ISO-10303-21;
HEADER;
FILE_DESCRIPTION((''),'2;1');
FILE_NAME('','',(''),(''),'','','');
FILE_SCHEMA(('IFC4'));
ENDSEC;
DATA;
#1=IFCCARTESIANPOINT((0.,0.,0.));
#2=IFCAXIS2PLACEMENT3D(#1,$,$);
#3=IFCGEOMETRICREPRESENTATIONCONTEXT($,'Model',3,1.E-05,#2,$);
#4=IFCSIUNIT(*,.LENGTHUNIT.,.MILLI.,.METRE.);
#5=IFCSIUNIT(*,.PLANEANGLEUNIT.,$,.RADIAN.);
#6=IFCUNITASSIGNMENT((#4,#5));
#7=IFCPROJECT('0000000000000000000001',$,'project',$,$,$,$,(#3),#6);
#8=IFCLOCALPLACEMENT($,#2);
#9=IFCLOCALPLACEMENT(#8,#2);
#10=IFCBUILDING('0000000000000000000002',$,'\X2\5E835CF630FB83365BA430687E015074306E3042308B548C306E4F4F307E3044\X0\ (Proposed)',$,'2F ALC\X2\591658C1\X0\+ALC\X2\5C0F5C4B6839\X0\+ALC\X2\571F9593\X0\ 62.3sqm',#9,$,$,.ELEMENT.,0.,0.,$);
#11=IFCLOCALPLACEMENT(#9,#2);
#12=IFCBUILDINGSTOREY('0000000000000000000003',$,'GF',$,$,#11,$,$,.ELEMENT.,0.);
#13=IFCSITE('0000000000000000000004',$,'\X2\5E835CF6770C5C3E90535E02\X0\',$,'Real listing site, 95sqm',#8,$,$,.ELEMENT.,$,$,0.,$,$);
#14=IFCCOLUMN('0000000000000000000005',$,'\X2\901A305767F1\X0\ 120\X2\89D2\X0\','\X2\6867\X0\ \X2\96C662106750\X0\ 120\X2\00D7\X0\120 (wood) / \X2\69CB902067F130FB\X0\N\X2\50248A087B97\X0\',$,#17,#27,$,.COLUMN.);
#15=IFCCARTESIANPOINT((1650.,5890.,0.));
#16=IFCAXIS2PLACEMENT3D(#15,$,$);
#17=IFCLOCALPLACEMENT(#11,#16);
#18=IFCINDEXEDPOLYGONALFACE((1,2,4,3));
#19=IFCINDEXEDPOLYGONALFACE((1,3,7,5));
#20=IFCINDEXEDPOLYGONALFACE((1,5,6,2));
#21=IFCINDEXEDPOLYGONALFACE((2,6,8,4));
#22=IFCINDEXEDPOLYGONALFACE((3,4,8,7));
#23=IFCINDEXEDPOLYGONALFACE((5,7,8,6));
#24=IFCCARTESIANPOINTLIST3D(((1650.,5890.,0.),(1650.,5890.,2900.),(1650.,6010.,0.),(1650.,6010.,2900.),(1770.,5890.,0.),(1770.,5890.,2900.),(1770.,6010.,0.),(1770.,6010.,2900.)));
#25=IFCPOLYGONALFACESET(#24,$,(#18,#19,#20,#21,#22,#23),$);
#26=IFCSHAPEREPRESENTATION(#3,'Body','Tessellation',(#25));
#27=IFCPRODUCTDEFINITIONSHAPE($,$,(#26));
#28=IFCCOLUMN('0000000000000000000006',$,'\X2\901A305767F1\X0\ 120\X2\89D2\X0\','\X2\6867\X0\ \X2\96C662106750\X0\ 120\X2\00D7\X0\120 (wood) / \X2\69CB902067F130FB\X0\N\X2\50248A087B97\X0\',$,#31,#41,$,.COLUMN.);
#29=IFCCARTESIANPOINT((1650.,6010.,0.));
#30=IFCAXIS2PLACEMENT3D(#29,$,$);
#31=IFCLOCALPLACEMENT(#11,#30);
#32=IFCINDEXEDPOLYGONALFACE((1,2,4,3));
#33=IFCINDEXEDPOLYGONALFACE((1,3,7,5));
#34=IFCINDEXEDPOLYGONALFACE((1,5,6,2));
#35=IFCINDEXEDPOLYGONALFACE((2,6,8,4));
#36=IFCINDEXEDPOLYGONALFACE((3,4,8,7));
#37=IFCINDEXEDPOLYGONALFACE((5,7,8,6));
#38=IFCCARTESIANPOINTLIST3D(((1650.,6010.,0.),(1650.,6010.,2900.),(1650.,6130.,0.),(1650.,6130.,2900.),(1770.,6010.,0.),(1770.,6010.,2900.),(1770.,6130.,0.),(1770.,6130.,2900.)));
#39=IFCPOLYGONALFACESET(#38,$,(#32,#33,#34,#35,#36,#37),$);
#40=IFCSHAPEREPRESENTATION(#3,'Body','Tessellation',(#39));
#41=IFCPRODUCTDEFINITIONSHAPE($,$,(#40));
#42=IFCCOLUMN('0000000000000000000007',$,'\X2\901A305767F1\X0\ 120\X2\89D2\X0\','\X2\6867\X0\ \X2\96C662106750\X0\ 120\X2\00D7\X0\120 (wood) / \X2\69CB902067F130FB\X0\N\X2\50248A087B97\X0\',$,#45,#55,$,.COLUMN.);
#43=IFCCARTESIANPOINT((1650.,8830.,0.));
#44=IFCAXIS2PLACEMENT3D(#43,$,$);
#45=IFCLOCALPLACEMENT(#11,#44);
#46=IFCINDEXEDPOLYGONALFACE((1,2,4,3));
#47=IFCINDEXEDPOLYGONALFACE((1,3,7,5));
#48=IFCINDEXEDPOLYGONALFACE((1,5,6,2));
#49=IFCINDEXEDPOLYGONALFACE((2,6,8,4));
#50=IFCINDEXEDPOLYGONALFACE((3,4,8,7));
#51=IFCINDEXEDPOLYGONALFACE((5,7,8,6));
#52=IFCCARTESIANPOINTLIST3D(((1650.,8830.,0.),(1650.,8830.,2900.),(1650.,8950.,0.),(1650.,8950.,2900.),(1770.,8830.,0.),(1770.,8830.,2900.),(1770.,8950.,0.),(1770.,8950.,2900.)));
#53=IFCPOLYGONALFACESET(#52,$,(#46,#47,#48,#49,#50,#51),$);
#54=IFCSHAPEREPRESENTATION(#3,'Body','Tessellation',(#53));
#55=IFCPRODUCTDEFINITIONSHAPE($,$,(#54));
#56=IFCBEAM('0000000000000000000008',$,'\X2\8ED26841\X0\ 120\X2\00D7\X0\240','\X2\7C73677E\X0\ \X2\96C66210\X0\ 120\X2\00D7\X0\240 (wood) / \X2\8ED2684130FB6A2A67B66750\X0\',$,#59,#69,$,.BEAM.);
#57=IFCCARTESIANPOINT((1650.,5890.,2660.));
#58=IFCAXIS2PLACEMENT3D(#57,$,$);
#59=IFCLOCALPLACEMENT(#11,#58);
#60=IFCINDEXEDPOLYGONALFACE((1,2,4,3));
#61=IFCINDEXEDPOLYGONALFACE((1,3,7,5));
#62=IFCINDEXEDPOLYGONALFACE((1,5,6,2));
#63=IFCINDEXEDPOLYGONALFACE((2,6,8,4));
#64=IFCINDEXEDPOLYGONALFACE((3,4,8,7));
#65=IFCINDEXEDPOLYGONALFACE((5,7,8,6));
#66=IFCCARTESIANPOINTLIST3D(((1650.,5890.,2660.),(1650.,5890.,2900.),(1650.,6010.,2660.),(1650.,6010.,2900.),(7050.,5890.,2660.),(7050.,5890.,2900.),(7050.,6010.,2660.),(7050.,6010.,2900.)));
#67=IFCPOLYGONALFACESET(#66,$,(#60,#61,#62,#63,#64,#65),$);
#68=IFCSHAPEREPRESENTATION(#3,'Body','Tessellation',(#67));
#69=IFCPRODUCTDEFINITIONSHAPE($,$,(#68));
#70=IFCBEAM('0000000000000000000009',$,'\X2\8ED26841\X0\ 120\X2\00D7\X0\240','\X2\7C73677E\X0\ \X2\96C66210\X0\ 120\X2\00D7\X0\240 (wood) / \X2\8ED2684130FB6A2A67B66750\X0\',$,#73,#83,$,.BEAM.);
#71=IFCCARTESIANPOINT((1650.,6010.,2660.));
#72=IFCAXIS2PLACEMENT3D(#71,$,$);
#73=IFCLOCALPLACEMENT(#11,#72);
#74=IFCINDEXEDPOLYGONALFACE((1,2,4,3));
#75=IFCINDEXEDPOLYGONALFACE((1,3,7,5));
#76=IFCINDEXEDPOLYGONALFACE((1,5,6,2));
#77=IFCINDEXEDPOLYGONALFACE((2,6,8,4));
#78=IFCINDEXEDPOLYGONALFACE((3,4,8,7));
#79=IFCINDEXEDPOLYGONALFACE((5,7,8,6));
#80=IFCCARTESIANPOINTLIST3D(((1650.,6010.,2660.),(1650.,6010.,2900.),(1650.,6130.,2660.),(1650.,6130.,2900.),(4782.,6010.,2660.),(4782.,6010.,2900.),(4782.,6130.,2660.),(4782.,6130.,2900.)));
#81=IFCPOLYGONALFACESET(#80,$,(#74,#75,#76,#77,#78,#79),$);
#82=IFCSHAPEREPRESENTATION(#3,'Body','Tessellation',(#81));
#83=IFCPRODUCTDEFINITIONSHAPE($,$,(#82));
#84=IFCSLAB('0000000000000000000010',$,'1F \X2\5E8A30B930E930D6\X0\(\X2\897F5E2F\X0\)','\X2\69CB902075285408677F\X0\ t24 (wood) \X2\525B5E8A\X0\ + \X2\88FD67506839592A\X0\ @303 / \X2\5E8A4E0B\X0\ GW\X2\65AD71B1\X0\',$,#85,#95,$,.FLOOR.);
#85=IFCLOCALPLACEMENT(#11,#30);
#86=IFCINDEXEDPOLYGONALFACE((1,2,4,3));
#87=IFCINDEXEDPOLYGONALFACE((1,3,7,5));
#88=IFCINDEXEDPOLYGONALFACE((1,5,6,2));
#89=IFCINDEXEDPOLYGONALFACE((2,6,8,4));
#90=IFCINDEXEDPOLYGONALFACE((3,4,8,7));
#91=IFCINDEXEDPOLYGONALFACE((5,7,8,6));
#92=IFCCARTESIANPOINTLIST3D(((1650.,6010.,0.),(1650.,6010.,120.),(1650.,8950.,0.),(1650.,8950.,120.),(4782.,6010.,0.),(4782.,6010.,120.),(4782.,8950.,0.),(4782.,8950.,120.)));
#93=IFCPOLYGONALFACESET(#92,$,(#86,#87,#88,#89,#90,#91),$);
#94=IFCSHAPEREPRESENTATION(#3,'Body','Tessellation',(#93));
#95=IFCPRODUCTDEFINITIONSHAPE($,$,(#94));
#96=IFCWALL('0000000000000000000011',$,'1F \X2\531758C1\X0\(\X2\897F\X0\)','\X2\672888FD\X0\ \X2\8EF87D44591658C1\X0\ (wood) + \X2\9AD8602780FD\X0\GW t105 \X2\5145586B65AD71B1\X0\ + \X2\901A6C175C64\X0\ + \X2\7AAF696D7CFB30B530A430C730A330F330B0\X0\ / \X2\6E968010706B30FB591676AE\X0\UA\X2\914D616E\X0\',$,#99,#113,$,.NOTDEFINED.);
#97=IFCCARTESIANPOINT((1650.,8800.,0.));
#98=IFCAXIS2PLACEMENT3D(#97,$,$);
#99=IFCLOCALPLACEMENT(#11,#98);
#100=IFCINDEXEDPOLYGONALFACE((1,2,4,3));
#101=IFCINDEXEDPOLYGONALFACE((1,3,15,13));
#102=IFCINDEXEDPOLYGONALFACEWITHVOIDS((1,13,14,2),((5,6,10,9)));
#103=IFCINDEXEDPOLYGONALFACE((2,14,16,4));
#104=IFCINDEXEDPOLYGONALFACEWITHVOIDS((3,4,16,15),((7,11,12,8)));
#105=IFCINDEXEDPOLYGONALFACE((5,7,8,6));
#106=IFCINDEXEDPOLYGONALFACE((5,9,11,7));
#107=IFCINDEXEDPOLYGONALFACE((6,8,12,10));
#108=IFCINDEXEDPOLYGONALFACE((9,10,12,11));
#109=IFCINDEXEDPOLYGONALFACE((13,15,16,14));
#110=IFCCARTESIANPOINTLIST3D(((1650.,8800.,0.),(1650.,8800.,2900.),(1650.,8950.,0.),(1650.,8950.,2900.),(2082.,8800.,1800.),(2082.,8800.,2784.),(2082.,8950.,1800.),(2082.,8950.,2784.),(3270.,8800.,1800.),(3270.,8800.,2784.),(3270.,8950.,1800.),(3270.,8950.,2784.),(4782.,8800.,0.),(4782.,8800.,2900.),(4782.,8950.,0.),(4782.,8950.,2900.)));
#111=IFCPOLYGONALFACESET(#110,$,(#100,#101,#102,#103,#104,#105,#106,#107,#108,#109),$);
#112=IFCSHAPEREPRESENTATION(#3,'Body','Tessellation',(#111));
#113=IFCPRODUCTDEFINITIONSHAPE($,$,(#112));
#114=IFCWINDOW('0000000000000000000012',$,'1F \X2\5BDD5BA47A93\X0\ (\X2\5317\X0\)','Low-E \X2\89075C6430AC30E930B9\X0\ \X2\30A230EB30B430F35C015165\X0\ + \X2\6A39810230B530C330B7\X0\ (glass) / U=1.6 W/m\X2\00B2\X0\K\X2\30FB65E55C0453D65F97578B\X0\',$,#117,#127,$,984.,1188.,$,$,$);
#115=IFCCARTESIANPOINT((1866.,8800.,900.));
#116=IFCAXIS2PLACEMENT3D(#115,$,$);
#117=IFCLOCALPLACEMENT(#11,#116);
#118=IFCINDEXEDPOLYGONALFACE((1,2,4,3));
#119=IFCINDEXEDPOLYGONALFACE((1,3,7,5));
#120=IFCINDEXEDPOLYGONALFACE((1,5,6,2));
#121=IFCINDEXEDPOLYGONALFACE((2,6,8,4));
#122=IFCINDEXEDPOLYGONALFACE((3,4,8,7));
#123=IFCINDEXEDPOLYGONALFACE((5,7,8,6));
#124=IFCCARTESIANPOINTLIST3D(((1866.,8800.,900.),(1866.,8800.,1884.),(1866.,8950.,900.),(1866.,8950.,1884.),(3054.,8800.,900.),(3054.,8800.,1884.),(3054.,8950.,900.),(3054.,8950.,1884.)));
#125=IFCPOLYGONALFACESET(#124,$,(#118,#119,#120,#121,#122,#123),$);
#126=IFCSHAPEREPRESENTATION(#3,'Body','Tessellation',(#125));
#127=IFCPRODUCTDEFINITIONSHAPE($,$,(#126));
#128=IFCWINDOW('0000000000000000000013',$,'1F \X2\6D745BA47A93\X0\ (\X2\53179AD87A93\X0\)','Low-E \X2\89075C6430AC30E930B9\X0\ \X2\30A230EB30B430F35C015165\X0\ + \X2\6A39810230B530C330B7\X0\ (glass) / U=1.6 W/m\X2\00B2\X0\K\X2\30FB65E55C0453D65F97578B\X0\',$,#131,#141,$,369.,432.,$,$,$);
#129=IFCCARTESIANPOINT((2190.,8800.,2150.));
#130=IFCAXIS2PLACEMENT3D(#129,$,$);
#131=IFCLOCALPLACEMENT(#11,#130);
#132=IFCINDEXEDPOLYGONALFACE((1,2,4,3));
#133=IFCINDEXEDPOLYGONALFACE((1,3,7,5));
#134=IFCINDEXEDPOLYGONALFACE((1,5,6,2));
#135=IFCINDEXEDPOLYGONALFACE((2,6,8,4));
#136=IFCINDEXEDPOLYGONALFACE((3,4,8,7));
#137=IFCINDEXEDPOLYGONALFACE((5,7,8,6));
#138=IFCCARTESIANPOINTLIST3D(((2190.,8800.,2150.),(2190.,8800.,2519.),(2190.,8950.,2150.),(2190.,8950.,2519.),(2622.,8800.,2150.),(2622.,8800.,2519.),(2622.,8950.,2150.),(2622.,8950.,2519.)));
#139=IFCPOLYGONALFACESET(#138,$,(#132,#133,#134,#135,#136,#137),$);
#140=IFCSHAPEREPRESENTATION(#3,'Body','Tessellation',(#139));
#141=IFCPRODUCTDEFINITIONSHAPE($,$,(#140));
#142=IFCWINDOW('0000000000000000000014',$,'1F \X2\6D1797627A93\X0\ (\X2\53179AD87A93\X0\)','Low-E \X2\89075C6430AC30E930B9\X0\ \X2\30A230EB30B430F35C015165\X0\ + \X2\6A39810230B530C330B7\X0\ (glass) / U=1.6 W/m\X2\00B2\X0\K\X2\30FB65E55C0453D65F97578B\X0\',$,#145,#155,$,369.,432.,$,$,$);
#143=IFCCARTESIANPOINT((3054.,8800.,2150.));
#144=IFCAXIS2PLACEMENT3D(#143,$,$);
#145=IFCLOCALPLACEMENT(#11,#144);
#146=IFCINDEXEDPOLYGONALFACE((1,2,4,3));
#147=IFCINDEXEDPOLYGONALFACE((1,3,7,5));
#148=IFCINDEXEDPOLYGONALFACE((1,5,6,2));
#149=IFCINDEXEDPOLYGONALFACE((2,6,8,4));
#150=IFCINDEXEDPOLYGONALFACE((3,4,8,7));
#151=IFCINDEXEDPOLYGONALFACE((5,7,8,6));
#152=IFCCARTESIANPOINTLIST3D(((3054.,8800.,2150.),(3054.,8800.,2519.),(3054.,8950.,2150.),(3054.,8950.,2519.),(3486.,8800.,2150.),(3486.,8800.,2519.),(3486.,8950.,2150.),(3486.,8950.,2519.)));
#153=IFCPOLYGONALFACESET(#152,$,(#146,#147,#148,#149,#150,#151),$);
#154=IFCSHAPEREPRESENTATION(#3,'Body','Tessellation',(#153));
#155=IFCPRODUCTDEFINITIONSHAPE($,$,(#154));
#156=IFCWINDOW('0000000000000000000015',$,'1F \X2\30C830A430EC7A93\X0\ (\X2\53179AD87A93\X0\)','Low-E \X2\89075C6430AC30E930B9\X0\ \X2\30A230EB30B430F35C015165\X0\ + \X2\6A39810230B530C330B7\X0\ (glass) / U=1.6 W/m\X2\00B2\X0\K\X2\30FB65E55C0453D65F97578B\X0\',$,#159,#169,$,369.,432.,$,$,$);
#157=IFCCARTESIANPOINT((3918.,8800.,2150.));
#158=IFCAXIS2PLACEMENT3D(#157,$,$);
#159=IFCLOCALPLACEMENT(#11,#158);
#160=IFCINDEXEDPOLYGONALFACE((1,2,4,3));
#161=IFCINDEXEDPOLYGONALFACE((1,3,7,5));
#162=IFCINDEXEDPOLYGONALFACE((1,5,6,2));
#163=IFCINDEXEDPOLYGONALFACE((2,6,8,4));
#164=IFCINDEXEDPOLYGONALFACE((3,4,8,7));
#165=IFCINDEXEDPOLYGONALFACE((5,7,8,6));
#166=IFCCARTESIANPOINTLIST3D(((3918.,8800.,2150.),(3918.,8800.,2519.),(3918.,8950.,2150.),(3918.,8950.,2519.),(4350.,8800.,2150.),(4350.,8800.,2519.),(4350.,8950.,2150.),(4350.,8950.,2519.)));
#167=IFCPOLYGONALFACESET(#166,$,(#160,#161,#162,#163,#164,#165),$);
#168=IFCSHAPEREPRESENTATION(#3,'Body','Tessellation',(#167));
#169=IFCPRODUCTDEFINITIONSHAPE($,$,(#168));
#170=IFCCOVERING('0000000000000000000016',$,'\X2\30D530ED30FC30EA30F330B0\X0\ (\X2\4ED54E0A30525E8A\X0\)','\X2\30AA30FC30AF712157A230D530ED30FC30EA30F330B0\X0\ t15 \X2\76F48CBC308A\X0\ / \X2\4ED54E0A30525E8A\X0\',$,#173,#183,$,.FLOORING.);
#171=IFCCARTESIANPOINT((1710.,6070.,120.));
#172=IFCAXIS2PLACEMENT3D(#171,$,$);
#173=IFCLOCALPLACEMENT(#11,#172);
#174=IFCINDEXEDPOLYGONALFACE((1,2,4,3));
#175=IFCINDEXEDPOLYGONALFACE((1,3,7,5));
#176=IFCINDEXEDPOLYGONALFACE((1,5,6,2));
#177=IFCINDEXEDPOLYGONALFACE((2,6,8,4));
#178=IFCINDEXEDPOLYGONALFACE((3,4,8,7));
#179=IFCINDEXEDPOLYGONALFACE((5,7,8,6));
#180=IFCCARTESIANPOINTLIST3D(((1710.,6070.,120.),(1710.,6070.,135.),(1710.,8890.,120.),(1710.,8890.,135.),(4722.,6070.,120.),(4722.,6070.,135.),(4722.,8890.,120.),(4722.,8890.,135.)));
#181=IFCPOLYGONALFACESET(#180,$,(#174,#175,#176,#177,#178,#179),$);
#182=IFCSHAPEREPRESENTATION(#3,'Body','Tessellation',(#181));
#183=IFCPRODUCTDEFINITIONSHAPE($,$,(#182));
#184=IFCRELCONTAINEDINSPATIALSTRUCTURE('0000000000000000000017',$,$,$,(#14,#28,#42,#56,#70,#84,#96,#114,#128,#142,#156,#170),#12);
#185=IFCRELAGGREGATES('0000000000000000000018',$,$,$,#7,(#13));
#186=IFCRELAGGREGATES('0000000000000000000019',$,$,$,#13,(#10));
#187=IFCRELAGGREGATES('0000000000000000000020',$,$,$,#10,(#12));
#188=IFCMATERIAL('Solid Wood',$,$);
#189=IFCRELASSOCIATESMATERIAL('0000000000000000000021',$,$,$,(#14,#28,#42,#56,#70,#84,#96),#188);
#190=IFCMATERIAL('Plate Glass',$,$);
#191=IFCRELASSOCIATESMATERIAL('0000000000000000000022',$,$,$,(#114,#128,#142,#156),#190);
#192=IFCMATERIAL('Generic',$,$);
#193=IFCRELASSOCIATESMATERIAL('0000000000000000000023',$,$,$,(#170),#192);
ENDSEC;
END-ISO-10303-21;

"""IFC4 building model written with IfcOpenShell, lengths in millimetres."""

from ifc_helpers import new_model, si_unit, frame, frame_2d, origin, place, context, project, spatial, rectangle, extrude, material, element, fill, save


model = new_model("IFC4")

# Units and contexts
model_context = context("Model", 3, precision=1e-05, world=origin())
ifc_project = project(units=[si_unit("LENGTHUNIT", "METRE", prefix="MILLI"), si_unit("PLANEANGLEUNIT", "RADIAN")], contexts=[model_context])

# Site, building, storey
site_placement = place(None, origin())
site = spatial("IfcSite", under=ifc_project, at=site_placement, Name="広島県尾道市", ObjectType="Real listing site, 95sqm", CompositionType="ELEMENT", RefElevation=0.0)
building_placement = place(site_placement, origin())
building = spatial("IfcBuilding", under=site, at=building_placement, Name="広島・茶室と縁側のある和の住まい (Proposed)", ObjectType="2F ALC外壁+ALC小屋根+ALC土間 62.3sqm", CompositionType="ELEMENT", ElevationOfRefHeight=0.0, ElevationOfTerrain=0.0)
storey_placement = place(building_placement, origin())
storey = spatial("IfcBuildingStorey", under=building, at=storey_placement, Name="GF", CompositionType="ELEMENT", Elevation=0.0)

# Columns
ifc_material_1 = material(Name="Solid Wood")
column_1_placement = place(storey_placement, frame((1650.0, 5890.0, 0.0)))
element("IfcColumn", 1, at=column_1_placement, inside=storey, material=ifc_material_1, Name="通し柱 120角", Description="桧 集成材 120×120 (wood) / 構造柱・N値計算", PredefinedType="COLUMN", context=model_context, shape_type="SweptSolid", body=[
    extrude(rectangle(XDim=120.0, YDim=120.0, at=frame_2d((60.0, 60.0))), frame((1650.0, 5890.0, 0.0)), (0.0, 0.0, 1.0), 2900.0),
])
column_2_placement = place(storey_placement, frame((1650.0, 6010.0, 0.0)))
element("IfcColumn", 2, at=column_2_placement, inside=storey, material=ifc_material_1, Name="通し柱 120角", Description="桧 集成材 120×120 (wood) / 構造柱・N値計算", PredefinedType="COLUMN", context=model_context, shape_type="SweptSolid", body=[
    extrude(rectangle(XDim=120.0, YDim=120.0, at=frame_2d((60.0, 60.0))), frame((1650.0, 6010.0, 0.0)), (0.0, 0.0, 1.0), 2900.0),
])
column_3_placement = place(storey_placement, frame((1650.0, 8830.0, 0.0)))
element("IfcColumn", 3, at=column_3_placement, inside=storey, material=ifc_material_1, Name="通し柱 120角", Description="桧 集成材 120×120 (wood) / 構造柱・N値計算", PredefinedType="COLUMN", context=model_context, shape_type="SweptSolid", body=[
    extrude(rectangle(XDim=120.0, YDim=120.0, at=frame_2d((60.0, 60.0))), frame((1650.0, 8830.0, 0.0)), (0.0, 0.0, 1.0), 2900.0),
])

# Beams
beam_1_placement = place(storey_placement, frame((1650.0, 5890.0, 2660.0)))
element("IfcBeam", 4, at=beam_1_placement, inside=storey, material=ifc_material_1, Name="軒桁 120×240", Description="米松 集成 120×240 (wood) / 軒桁・横架材", PredefinedType="BEAM", context=model_context, shape_type="SweptSolid", body=[
    extrude(rectangle(XDim=5400.0, YDim=120.0, at=frame_2d((2700.0, 60.0))), frame((1650.0, 5890.0, 2660.0)), (0.0, 0.0, 1.0), 240.0),
])
beam_2_placement = place(storey_placement, frame((1650.0, 6010.0, 2660.0)))
element("IfcBeam", 5, at=beam_2_placement, inside=storey, material=ifc_material_1, Name="軒桁 120×240", Description="米松 集成 120×240 (wood) / 軒桁・横架材", PredefinedType="BEAM", context=model_context, shape_type="SweptSolid", body=[
    extrude(rectangle(XDim=3132.0, YDim=120.0, at=frame_2d((1566.0, 60.0))), frame((1650.0, 6010.0, 2660.0)), (0.0, 0.0, 1.0), 240.0),
])

# Slab
slab_placement = place(storey_placement, frame((1650.0, 6010.0, 0.0)))
element("IfcSlab", 6, at=slab_placement, inside=storey, material=ifc_material_1, Name="1F 床スラブ(西帯)", Description="構造用合板 t24 (wood) 剛床 + 製材根太 @303 / 床下 GW断熱", PredefinedType="FLOOR", context=model_context, shape_type="SweptSolid", body=[
    extrude(rectangle(XDim=3132.0, YDim=2940.0, at=frame_2d((1566.0, 1470.0))), frame((1650.0, 6010.0, 0.0)), (0.0, 0.0, 1.0), 120.0),
])

# Wall, openings, windows
wall_1_placement = place(storey_placement, frame((1650.0, 8800.0, 0.0)))
wall_1 = element("IfcWall", 7, at=wall_1_placement, inside=storey, material=ifc_material_1, Name="1F 北壁(西)", Description="木製 軸組外壁 (wood) + 高性能GW t105 充填断熱 + 通気層 + 窯業系サイディング / 準耐火・外皮UA配慮", PredefinedType="NOTDEFINED", context=model_context, shape_type="SweptSolid", body=[
    extrude(rectangle(XDim=3132.0, YDim=150.0, at=frame_2d((1566.0, 75.0))), frame((1650.0, 8800.0, 0.0)), (0.0, 0.0, 1.0), 2900.0),
])
opening_1_placement = place(storey_placement, frame((1866.0, 8800.0, 900.0)))
opening_1 = element("IfcOpeningElement", 8, at=opening_1_placement, cuts=wall_1, PredefinedType="NOTDEFINED", context=model_context, shape_type="SweptSolid", body=[
    extrude(rectangle(XDim=1188.0, YDim=150.0, at=frame_2d((594.0, 75.0))), frame((1866.0, 8800.0, 900.0)), (0.0, 0.0, 1.0), 984.0),
])
opening_2_placement = place(storey_placement, frame((2190.0, 8800.0, 2150.0)))
opening_2 = element("IfcOpeningElement", 9, at=opening_2_placement, cuts=wall_1, PredefinedType="NOTDEFINED", context=model_context, shape_type="SweptSolid", body=[
    extrude(rectangle(XDim=432.0, YDim=150.0, at=frame_2d((216.0, 75.0))), frame((2190.0, 8800.0, 2150.0)), (0.0, 0.0, 1.0), 369.0),
])
opening_3_placement = place(storey_placement, frame((3054.0, 8800.0, 2150.0)))
opening_3 = element("IfcOpeningElement", 10, at=opening_3_placement, cuts=wall_1, PredefinedType="NOTDEFINED", context=model_context, shape_type="SweptSolid", body=[
    extrude(rectangle(XDim=432.0, YDim=150.0, at=frame_2d((216.0, 75.0))), frame((3054.0, 8800.0, 2150.0)), (0.0, 0.0, 1.0), 369.0),
])
opening_4_placement = place(storey_placement, frame((3918.0, 8800.0, 2150.0)))
opening_4 = element("IfcOpeningElement", 11, at=opening_4_placement, cuts=wall_1, PredefinedType="NOTDEFINED", context=model_context, shape_type="SweptSolid", body=[
    extrude(rectangle(XDim=432.0, YDim=150.0, at=frame_2d((216.0, 75.0))), frame((3918.0, 8800.0, 2150.0)), (0.0, 0.0, 1.0), 369.0),
])
ifc_material_2 = material(Name="Plate Glass")
window_1_placement = place(storey_placement, frame((1866.0, 8800.0, 900.0)))
window_1 = element("IfcWindow", 12, at=window_1_placement, inside=storey, material=ifc_material_2, Name="1F 寝室窓 (北)", Description="Low-E 複層ガラス アルゴン封入 + 樹脂サッシ (glass) / U=1.6 W/m²K・日射取得型", OverallHeight=984.0, OverallWidth=1188.0, context=model_context, shape_type="SweptSolid", body=[
    extrude(rectangle(XDim=1188.0, YDim=150.0, at=frame_2d((594.0, 75.0))), frame((1866.0, 8800.0, 900.0)), (0.0, 0.0, 1.0), 984.0),
])
fill(opening_1, window_1)
window_2_placement = place(storey_placement, frame((2190.0, 8800.0, 2150.0)))
window_2 = element("IfcWindow", 13, at=window_2_placement, inside=storey, material=ifc_material_2, Name="1F 浴室窓 (北高窓)", Description="Low-E 複層ガラス アルゴン封入 + 樹脂サッシ (glass) / U=1.6 W/m²K・日射取得型", OverallHeight=369.0, OverallWidth=432.0, context=model_context, shape_type="SweptSolid", body=[
    extrude(rectangle(XDim=432.0, YDim=150.0, at=frame_2d((216.0, 75.0))), frame((2190.0, 8800.0, 2150.0)), (0.0, 0.0, 1.0), 369.0),
])
fill(opening_2, window_2)
window_3_placement = place(storey_placement, frame((3054.0, 8800.0, 2150.0)))
window_3 = element("IfcWindow", 14, at=window_3_placement, inside=storey, material=ifc_material_2, Name="1F 洗面窓 (北高窓)", Description="Low-E 複層ガラス アルゴン封入 + 樹脂サッシ (glass) / U=1.6 W/m²K・日射取得型", OverallHeight=369.0, OverallWidth=432.0, context=model_context, shape_type="SweptSolid", body=[
    extrude(rectangle(XDim=432.0, YDim=150.0, at=frame_2d((216.0, 75.0))), frame((3054.0, 8800.0, 2150.0)), (0.0, 0.0, 1.0), 369.0),
])
fill(opening_3, window_3)
window_4_placement = place(storey_placement, frame((3918.0, 8800.0, 2150.0)))
window_4 = element("IfcWindow", 15, at=window_4_placement, inside=storey, material=ifc_material_2, Name="1F トイレ窓 (北高窓)", Description="Low-E 複層ガラス アルゴン封入 + 樹脂サッシ (glass) / U=1.6 W/m²K・日射取得型", OverallHeight=369.0, OverallWidth=432.0, context=model_context, shape_type="SweptSolid", body=[
    extrude(rectangle(XDim=432.0, YDim=150.0, at=frame_2d((216.0, 75.0))), frame((3918.0, 8800.0, 2150.0)), (0.0, 0.0, 1.0), 369.0),
])
fill(opening_4, window_4)

# Covering
ifc_material_3 = material(Name="Generic")
covering_placement = place(storey_placement, frame((1710.0, 6070.0, 120.0)))
element("IfcCovering", 16, at=covering_placement, inside=storey, material=ifc_material_3, Name="フローリング (仕上げ床)", Description="オーク無垢フローリング t15 直貼り / 仕上げ床", PredefinedType="FLOORING", context=model_context, shape_type="SweptSolid", body=[
    extrude(rectangle(XDim=3012.0, YDim=2820.0, at=frame_2d((1506.0, 1410.0))), frame((1710.0, 6070.0, 120.0)), (0.0, 0.0, 1.0), 15.0),
])

save(model, "model.ifc")
